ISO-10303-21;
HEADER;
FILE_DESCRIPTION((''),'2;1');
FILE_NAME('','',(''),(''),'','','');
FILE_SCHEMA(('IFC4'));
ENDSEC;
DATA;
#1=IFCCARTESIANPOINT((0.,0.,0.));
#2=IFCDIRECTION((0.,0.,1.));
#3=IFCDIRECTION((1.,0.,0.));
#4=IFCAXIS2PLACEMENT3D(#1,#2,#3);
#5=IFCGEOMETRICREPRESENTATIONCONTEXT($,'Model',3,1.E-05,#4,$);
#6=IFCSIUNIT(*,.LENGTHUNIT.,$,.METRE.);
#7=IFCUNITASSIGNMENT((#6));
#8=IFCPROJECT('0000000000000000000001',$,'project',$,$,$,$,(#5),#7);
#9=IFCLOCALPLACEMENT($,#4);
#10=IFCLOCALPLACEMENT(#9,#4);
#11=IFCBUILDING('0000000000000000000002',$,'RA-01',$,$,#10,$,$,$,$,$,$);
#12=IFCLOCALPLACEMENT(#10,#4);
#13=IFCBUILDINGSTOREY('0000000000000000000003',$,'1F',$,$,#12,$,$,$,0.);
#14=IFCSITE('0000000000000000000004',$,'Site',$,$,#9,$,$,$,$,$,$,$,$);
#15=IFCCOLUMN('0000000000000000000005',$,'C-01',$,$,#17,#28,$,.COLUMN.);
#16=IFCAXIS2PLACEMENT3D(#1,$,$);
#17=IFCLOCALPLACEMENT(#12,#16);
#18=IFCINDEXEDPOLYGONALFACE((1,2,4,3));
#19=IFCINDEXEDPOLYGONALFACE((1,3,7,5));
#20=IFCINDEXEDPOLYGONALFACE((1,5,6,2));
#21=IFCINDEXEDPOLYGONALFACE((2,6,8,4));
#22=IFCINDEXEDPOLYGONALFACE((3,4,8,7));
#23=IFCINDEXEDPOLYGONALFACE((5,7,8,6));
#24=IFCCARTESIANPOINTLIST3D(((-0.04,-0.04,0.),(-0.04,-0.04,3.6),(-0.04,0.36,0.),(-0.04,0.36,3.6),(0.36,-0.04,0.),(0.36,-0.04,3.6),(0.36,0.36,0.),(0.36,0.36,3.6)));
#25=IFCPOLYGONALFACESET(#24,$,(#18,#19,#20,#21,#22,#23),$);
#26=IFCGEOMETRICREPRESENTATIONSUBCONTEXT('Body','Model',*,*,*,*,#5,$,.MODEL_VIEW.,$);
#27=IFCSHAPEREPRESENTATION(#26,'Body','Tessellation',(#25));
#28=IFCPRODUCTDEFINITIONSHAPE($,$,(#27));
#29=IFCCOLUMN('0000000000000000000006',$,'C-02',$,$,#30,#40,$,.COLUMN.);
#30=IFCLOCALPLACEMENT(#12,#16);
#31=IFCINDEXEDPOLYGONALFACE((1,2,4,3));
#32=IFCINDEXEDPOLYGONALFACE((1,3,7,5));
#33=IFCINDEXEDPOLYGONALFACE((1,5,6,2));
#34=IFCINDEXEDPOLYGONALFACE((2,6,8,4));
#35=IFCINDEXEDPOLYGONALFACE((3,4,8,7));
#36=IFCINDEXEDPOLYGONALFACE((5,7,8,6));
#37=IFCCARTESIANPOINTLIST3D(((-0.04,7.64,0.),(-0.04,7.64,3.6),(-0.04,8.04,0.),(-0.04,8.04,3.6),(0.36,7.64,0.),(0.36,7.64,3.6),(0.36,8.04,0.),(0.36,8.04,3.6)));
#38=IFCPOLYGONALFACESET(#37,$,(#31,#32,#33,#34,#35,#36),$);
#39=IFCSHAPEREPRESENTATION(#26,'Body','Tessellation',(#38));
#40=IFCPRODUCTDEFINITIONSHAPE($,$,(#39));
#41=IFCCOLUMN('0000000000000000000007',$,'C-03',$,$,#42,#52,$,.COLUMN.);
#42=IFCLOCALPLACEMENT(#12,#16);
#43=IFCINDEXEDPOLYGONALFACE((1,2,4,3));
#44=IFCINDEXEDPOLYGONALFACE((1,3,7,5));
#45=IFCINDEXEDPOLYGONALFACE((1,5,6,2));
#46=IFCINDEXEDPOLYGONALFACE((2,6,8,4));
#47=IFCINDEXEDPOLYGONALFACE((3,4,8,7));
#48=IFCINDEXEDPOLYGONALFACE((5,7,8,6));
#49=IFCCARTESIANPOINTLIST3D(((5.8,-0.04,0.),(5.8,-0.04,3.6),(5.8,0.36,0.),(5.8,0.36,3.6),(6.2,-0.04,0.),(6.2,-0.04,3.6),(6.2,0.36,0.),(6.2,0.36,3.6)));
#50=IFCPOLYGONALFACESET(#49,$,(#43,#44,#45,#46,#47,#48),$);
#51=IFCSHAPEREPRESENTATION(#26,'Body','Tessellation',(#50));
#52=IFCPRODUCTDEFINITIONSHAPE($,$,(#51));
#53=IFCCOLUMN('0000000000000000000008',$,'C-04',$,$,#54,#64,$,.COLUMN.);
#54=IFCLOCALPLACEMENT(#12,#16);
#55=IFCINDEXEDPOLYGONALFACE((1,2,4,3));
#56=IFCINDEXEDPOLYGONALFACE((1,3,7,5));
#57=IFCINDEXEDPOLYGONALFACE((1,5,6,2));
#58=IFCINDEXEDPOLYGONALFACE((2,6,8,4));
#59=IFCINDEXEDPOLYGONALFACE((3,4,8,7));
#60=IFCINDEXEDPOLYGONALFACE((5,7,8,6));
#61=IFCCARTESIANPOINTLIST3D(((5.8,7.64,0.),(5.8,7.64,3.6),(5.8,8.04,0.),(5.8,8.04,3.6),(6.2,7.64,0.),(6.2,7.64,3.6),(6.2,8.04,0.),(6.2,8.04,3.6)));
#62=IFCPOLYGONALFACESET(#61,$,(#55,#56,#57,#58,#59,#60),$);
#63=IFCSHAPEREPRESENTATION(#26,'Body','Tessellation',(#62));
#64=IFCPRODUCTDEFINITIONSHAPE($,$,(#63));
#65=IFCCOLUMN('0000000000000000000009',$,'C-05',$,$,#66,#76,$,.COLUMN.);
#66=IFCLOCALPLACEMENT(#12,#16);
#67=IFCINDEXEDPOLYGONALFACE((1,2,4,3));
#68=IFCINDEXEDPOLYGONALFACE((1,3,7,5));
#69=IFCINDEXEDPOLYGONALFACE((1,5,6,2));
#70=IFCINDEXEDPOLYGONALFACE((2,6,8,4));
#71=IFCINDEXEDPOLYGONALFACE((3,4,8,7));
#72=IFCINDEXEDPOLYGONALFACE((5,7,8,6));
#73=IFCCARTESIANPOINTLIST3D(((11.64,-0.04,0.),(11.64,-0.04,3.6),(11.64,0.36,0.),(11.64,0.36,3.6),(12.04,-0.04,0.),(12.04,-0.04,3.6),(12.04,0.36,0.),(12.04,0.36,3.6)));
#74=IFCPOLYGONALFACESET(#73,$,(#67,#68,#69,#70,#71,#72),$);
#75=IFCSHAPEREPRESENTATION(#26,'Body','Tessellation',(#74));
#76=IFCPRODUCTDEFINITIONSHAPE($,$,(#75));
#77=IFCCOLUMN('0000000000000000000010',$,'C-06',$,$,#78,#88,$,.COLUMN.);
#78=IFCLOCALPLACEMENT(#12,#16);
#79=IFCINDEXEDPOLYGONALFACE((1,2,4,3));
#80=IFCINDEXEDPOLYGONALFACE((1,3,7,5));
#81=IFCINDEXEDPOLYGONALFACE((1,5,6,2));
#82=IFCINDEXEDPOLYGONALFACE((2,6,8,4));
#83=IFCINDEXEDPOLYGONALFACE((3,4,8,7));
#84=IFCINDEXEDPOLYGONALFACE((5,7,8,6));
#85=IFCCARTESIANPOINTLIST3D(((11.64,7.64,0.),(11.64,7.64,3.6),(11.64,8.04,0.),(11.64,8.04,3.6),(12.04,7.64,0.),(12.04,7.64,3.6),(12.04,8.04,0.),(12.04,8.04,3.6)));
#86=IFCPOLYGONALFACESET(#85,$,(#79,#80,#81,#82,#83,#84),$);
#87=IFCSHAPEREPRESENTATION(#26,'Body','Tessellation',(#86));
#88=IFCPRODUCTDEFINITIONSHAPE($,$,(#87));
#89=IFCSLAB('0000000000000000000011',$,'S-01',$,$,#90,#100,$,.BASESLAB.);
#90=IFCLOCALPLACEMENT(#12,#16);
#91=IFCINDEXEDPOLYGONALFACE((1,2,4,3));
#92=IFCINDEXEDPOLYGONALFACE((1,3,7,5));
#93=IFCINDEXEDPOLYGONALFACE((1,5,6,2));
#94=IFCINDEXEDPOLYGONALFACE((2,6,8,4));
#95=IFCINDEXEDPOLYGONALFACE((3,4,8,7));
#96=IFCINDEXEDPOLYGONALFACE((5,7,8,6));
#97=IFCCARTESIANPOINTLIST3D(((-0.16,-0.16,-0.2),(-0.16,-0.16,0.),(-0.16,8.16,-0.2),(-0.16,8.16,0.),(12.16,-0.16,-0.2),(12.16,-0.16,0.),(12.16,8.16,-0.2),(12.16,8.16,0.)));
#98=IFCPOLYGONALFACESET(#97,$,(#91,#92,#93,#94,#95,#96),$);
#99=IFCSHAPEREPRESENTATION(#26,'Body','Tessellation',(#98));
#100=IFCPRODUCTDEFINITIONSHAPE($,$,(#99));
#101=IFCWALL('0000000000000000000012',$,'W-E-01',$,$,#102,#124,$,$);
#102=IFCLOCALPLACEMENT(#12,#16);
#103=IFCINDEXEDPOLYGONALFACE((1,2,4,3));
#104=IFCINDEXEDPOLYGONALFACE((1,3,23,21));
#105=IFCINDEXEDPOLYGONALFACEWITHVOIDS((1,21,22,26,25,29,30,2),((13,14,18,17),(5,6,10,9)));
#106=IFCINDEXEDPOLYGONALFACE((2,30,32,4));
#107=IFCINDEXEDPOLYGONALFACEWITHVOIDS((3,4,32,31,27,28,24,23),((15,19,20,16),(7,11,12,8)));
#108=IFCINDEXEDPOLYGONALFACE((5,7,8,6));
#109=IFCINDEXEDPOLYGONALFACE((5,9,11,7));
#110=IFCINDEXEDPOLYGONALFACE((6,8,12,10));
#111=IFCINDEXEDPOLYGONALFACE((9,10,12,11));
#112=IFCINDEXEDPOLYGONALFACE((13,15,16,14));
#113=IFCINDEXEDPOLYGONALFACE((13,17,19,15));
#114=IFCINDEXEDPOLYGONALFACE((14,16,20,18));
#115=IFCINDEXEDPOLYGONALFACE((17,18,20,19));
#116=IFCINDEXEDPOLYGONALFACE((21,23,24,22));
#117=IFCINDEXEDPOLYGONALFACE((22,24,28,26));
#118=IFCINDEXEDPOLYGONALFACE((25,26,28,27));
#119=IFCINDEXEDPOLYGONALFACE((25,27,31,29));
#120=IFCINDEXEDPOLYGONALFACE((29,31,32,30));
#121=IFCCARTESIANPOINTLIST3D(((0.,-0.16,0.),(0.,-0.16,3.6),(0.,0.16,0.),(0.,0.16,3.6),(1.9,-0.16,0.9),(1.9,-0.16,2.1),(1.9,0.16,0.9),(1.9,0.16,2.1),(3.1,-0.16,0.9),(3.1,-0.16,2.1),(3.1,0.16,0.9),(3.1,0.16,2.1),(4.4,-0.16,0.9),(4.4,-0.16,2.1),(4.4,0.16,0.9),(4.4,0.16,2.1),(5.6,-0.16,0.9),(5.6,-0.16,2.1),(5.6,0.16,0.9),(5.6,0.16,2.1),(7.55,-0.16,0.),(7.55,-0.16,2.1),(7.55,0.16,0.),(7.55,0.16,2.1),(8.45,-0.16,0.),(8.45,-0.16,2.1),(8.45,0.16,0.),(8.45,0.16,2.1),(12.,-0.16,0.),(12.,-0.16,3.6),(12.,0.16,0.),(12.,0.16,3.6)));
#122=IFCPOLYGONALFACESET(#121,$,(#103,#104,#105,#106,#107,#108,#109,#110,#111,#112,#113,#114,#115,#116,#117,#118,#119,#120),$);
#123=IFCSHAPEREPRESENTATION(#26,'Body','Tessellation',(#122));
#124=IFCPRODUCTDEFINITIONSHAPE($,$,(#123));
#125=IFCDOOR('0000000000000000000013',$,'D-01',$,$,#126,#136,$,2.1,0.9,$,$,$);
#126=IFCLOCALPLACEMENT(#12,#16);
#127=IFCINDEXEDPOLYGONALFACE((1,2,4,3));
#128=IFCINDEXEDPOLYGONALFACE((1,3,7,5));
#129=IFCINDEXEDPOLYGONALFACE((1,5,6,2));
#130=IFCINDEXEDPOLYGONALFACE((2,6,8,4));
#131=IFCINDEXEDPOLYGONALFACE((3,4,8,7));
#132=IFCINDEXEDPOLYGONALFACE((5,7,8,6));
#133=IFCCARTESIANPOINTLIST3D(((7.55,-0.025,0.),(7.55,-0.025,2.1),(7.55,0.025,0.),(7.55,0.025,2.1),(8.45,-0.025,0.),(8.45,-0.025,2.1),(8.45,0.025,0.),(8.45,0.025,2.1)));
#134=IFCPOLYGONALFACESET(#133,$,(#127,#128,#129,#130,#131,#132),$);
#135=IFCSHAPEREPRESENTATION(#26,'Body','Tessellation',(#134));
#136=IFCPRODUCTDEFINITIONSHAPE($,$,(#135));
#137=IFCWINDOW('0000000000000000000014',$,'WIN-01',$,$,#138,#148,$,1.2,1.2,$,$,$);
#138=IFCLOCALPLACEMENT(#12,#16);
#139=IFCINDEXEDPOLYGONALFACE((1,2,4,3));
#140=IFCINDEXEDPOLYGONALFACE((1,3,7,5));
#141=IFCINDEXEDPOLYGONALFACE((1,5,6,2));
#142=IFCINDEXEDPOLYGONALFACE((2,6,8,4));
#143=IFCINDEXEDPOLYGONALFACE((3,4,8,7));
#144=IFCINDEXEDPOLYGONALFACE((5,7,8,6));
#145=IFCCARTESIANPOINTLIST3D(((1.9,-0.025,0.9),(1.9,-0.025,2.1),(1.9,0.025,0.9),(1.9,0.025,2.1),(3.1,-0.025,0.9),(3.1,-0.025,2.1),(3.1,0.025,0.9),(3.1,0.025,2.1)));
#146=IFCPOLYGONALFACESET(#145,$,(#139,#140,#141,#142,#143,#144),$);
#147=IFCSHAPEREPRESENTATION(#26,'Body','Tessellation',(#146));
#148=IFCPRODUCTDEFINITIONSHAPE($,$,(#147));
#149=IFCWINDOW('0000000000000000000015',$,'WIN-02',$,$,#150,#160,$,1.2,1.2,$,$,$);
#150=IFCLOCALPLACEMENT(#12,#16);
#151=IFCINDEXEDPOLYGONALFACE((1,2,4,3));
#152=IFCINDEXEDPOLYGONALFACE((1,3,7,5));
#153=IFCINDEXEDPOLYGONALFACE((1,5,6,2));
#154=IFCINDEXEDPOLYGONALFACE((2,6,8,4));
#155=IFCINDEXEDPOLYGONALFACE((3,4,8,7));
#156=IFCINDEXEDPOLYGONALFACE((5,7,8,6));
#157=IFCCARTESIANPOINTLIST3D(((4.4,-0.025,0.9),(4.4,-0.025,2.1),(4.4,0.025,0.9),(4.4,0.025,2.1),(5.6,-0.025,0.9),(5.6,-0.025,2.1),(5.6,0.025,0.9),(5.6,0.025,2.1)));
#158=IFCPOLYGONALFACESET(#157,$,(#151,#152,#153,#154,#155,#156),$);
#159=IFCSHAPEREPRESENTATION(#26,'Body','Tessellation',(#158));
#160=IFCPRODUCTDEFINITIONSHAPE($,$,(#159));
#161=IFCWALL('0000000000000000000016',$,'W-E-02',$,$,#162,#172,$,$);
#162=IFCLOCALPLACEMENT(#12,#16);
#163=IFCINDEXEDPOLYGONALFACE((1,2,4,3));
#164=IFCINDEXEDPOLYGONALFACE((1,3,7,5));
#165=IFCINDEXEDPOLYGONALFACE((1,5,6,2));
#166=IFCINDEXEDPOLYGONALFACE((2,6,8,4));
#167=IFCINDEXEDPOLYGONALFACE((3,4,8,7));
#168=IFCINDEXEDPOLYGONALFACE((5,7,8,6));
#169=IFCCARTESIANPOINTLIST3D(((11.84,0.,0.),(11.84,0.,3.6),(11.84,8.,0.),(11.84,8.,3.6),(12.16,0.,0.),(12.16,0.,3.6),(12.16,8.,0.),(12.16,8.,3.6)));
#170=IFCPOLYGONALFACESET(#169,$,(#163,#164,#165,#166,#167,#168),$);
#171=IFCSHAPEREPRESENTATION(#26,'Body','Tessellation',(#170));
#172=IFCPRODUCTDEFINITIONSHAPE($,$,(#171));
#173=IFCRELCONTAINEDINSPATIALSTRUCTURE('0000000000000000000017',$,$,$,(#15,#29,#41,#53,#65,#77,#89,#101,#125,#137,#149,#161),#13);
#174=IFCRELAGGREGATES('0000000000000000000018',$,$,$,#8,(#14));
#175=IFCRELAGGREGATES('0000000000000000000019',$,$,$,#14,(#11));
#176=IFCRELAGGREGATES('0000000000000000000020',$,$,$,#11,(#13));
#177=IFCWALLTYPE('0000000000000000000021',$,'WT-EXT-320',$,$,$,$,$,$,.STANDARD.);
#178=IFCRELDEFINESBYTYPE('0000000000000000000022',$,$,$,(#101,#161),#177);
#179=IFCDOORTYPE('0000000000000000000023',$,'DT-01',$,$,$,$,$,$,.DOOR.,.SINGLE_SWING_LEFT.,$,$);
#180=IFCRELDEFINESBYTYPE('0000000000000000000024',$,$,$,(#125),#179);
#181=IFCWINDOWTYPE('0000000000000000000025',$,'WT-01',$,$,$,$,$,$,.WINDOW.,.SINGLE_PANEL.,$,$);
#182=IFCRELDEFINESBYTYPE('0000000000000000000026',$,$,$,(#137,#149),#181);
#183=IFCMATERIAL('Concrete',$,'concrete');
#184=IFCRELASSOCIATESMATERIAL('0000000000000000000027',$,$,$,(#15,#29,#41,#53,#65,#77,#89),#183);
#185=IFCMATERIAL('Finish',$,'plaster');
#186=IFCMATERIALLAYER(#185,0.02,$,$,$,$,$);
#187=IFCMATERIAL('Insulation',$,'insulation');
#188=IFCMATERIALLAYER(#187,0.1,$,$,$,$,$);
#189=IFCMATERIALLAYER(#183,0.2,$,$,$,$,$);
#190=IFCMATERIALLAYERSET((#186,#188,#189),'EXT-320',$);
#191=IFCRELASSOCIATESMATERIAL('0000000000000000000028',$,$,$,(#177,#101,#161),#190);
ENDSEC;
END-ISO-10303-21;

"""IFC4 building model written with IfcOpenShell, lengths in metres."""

from ifc_helpers import new_model, si_unit, frame, frame_2d, origin_with_axes, origin_2d_with_axis, place, context, subcontext, project, spatial, polyline, rectangle, outline, extrude, material, layer, layer_set, layer_usage, type_object, element, fill, save


model = new_model("IFC4")

# Units and contexts
model_context = context("Model", 3, precision=1e-05, world=origin_with_axes())
body_context = subcontext(model_context, "Body", "Model", "MODEL_VIEW")
ifc_project = project(units=[si_unit("LENGTHUNIT", "METRE")], contexts=[model_context])

# Site, building, storey
site_placement = place(None, origin_with_axes())
site = spatial("IfcSite", under=ifc_project, at=site_placement, Name="Site")
building_placement = place(site_placement, origin_with_axes())
building = spatial("IfcBuilding", under=site, at=building_placement, Name="RA-01")
storey_placement = place(building_placement, origin_with_axes())
storey = spatial("IfcBuildingStorey", under=building, at=storey_placement, Name="1F", Elevation=0.0)

# Columns
ifc_material_1 = material(Name="Concrete", Category="concrete")
for number, where, z_axis, x_axis, name in (
    (1, (0.16, 0.16, 0.0), (0.0, 0.0, 1.0), (1.0, 0.0, 0.0), "C-01"),
    (2, (0.16, 7.84, 0.0), (0.0, 0.0, 1.0), (1.0, 0.0, 0.0), "C-02"),
    (3, (6.0, 0.16, 0.0), (0.0, 0.0, 1.0), (1.0, 0.0, 0.0), "C-03"),
    (4, (6.0, 7.84, 0.0), (0.0, 0.0, 1.0), (1.0, 0.0, 0.0), "C-04"),
    (5, (11.84, 0.16, 0.0), (0.0, 0.0, 1.0), (1.0, 0.0, 0.0), "C-05"),
    (6, (11.84, 7.84, 0.0), (0.0, 0.0, 1.0), (1.0, 0.0, 0.0), "C-06"),
):
    element("IfcColumn", number, at=place(storey_placement, frame(where, z_axis=z_axis, x_axis=x_axis)), inside=storey, material=ifc_material_1, Name=name, PredefinedType="COLUMN", context=body_context, shape_type="SweptSolid", body=[
        extrude(rectangle(XDim=0.4, YDim=0.4, at=origin_2d_with_axis()), origin_with_axes(), (0.0, 0.0, 1.0), 3.6),
    ])

# Slab
slab_placement = place(storey_placement, frame((0.0, 0.0, -0.2), z_axis=(0.0, 0.0, 1.0), x_axis=(1.0, 0.0, 0.0)))
element("IfcSlab", 7, at=slab_placement, inside=storey, material=ifc_material_1, Name="S-01", PredefinedType="BASESLAB", context=body_context, shape_type="SweptSolid", body=[
    extrude(outline(polyline([(-0.16, -0.16), (12.16, -0.16), (12.16, 8.16), (-0.16, 8.16), (-0.16, -0.16)])), origin_with_axes(), (0.0, 0.0, 1.0), 0.2),
])

# Wall, openings, door, windows
ifc_material_2 = material(Name="Finish", Category="plaster")
ifc_layer_1 = layer(ifc_material_2, 0.02)
ifc_material_3 = material(Name="Insulation", Category="insulation")
ifc_layer_2 = layer(ifc_material_3, 0.1)
ifc_layer_3 = layer(ifc_material_1, 0.2)
ifc_layer_set_1 = layer_set([ifc_layer_1, ifc_layer_2, ifc_layer_3], Name="EXT-320")
ifc_layer_usage_1 = layer_usage(ifc_layer_set_1, "AXIS2", "POSITIVE", -0.16)
wall_type_1 = type_object("IfcWallType", Name="WT-EXT-320", PredefinedType="STANDARD", material=ifc_layer_set_1)
wall_1_placement = place(storey_placement, origin_with_axes())
wall_1 = element("IfcWall", 8, at=wall_1_placement, inside=storey, type_object=wall_type_1, material=ifc_layer_usage_1, Name="W-E-01", context=body_context, shape_type="SweptSolid", body=[
    extrude(rectangle(XDim=12.0, YDim=0.32, at=frame_2d((6.0, 0.0), x_axis=(1.0, 0.0))), origin_with_axes(), (0.0, 0.0, 1.0), 3.6),
])
opening_1_placement = place(wall_1_placement, frame((8.0, 0.0, 0.0), z_axis=(0.0, 0.0, 1.0), x_axis=(1.0, 0.0, 0.0)))
opening_1 = element("IfcOpeningElement", 9, at=opening_1_placement, cuts=wall_1, PredefinedType="OPENING", context=body_context, shape_type="SweptSolid", body=[
    extrude(rectangle(XDim=0.9, YDim=0.42, at=origin_2d_with_axis()), origin_with_axes(), (0.0, 0.0, 1.0), 2.1),
])
opening_2_placement = place(wall_1_placement, frame((2.5, 0.0, 0.9), z_axis=(0.0, 0.0, 1.0), x_axis=(1.0, 0.0, 0.0)))
opening_2 = element("IfcOpeningElement", 10, at=opening_2_placement, cuts=wall_1, PredefinedType="OPENING", context=body_context, shape_type="SweptSolid", body=[
    extrude(rectangle(XDim=1.2, YDim=0.42, at=origin_2d_with_axis()), origin_with_axes(), (0.0, 0.0, 1.0), 1.2),
])
opening_3_placement = place(wall_1_placement, frame((5.0, 0.0, 0.9), z_axis=(0.0, 0.0, 1.0), x_axis=(1.0, 0.0, 0.0)))
opening_3 = element("IfcOpeningElement", 11, at=opening_3_placement, cuts=wall_1, PredefinedType="OPENING", context=body_context, shape_type="SweptSolid", body=[
    extrude(rectangle(XDim=1.2, YDim=0.42, at=origin_2d_with_axis()), origin_with_axes(), (0.0, 0.0, 1.0), 1.2),
])
door_type_1 = type_object("IfcDoorType", Name="DT-01", OperationType="SINGLE_SWING_LEFT", PredefinedType="DOOR")
door_1_placement = place(opening_1_placement, origin_with_axes())
door_1 = element("IfcDoor", 12, at=door_1_placement, inside=storey, type_object=door_type_1, Name="D-01", OverallHeight=2.1, OverallWidth=0.9, context=body_context, shape_type="SweptSolid", body=[
    extrude(rectangle(XDim=0.9, YDim=0.05, at=origin_2d_with_axis()), origin_with_axes(), (0.0, 0.0, 1.0), 2.1),
])
fill(opening_1, door_1)
window_type_1 = type_object("IfcWindowType", Name="WT-01", PartitioningType="SINGLE_PANEL", PredefinedType="WINDOW")
window_1_placement = place(opening_2_placement, origin_with_axes())
window_1 = element("IfcWindow", 13, at=window_1_placement, inside=storey, type_object=window_type_1, Name="WIN-01", OverallHeight=1.2, OverallWidth=1.2, context=body_context, shape_type="SweptSolid", body=[
    extrude(rectangle(XDim=1.2, YDim=0.05, at=origin_2d_with_axis()), origin_with_axes(), (0.0, 0.0, 1.0), 1.2),
])
fill(opening_2, window_1)
window_2_placement = place(opening_3_placement, origin_with_axes())
window_2 = element("IfcWindow", 14, at=window_2_placement, inside=storey, type_object=window_type_1, Name="WIN-02", OverallHeight=1.2, OverallWidth=1.2, context=body_context, shape_type="SweptSolid", body=[
    extrude(rectangle(XDim=1.2, YDim=0.05, at=origin_2d_with_axis()), origin_with_axes(), (0.0, 0.0, 1.0), 1.2),
])
fill(opening_3, window_2)

# Wall
ifc_layer_usage_2 = layer_usage(ifc_layer_set_1, "AXIS2", "POSITIVE", -0.16)
wall_2_placement = place(storey_placement, frame((12.0, 0.0, 0.0), z_axis=(0.0, 0.0, 1.0), x_axis=(0.0, 1.0, 0.0)))
element("IfcWall", 15, at=wall_2_placement, inside=storey, type_object=wall_type_1, material=ifc_layer_usage_2, Name="W-E-02", context=body_context, shape_type="SweptSolid", body=[
    extrude(rectangle(XDim=8.0, YDim=0.32, at=frame_2d((4.0, 0.0), x_axis=(1.0, 0.0))), origin_with_axes(), (0.0, 0.0, 1.0), 3.6),
])

save(model, "model.ifc")
